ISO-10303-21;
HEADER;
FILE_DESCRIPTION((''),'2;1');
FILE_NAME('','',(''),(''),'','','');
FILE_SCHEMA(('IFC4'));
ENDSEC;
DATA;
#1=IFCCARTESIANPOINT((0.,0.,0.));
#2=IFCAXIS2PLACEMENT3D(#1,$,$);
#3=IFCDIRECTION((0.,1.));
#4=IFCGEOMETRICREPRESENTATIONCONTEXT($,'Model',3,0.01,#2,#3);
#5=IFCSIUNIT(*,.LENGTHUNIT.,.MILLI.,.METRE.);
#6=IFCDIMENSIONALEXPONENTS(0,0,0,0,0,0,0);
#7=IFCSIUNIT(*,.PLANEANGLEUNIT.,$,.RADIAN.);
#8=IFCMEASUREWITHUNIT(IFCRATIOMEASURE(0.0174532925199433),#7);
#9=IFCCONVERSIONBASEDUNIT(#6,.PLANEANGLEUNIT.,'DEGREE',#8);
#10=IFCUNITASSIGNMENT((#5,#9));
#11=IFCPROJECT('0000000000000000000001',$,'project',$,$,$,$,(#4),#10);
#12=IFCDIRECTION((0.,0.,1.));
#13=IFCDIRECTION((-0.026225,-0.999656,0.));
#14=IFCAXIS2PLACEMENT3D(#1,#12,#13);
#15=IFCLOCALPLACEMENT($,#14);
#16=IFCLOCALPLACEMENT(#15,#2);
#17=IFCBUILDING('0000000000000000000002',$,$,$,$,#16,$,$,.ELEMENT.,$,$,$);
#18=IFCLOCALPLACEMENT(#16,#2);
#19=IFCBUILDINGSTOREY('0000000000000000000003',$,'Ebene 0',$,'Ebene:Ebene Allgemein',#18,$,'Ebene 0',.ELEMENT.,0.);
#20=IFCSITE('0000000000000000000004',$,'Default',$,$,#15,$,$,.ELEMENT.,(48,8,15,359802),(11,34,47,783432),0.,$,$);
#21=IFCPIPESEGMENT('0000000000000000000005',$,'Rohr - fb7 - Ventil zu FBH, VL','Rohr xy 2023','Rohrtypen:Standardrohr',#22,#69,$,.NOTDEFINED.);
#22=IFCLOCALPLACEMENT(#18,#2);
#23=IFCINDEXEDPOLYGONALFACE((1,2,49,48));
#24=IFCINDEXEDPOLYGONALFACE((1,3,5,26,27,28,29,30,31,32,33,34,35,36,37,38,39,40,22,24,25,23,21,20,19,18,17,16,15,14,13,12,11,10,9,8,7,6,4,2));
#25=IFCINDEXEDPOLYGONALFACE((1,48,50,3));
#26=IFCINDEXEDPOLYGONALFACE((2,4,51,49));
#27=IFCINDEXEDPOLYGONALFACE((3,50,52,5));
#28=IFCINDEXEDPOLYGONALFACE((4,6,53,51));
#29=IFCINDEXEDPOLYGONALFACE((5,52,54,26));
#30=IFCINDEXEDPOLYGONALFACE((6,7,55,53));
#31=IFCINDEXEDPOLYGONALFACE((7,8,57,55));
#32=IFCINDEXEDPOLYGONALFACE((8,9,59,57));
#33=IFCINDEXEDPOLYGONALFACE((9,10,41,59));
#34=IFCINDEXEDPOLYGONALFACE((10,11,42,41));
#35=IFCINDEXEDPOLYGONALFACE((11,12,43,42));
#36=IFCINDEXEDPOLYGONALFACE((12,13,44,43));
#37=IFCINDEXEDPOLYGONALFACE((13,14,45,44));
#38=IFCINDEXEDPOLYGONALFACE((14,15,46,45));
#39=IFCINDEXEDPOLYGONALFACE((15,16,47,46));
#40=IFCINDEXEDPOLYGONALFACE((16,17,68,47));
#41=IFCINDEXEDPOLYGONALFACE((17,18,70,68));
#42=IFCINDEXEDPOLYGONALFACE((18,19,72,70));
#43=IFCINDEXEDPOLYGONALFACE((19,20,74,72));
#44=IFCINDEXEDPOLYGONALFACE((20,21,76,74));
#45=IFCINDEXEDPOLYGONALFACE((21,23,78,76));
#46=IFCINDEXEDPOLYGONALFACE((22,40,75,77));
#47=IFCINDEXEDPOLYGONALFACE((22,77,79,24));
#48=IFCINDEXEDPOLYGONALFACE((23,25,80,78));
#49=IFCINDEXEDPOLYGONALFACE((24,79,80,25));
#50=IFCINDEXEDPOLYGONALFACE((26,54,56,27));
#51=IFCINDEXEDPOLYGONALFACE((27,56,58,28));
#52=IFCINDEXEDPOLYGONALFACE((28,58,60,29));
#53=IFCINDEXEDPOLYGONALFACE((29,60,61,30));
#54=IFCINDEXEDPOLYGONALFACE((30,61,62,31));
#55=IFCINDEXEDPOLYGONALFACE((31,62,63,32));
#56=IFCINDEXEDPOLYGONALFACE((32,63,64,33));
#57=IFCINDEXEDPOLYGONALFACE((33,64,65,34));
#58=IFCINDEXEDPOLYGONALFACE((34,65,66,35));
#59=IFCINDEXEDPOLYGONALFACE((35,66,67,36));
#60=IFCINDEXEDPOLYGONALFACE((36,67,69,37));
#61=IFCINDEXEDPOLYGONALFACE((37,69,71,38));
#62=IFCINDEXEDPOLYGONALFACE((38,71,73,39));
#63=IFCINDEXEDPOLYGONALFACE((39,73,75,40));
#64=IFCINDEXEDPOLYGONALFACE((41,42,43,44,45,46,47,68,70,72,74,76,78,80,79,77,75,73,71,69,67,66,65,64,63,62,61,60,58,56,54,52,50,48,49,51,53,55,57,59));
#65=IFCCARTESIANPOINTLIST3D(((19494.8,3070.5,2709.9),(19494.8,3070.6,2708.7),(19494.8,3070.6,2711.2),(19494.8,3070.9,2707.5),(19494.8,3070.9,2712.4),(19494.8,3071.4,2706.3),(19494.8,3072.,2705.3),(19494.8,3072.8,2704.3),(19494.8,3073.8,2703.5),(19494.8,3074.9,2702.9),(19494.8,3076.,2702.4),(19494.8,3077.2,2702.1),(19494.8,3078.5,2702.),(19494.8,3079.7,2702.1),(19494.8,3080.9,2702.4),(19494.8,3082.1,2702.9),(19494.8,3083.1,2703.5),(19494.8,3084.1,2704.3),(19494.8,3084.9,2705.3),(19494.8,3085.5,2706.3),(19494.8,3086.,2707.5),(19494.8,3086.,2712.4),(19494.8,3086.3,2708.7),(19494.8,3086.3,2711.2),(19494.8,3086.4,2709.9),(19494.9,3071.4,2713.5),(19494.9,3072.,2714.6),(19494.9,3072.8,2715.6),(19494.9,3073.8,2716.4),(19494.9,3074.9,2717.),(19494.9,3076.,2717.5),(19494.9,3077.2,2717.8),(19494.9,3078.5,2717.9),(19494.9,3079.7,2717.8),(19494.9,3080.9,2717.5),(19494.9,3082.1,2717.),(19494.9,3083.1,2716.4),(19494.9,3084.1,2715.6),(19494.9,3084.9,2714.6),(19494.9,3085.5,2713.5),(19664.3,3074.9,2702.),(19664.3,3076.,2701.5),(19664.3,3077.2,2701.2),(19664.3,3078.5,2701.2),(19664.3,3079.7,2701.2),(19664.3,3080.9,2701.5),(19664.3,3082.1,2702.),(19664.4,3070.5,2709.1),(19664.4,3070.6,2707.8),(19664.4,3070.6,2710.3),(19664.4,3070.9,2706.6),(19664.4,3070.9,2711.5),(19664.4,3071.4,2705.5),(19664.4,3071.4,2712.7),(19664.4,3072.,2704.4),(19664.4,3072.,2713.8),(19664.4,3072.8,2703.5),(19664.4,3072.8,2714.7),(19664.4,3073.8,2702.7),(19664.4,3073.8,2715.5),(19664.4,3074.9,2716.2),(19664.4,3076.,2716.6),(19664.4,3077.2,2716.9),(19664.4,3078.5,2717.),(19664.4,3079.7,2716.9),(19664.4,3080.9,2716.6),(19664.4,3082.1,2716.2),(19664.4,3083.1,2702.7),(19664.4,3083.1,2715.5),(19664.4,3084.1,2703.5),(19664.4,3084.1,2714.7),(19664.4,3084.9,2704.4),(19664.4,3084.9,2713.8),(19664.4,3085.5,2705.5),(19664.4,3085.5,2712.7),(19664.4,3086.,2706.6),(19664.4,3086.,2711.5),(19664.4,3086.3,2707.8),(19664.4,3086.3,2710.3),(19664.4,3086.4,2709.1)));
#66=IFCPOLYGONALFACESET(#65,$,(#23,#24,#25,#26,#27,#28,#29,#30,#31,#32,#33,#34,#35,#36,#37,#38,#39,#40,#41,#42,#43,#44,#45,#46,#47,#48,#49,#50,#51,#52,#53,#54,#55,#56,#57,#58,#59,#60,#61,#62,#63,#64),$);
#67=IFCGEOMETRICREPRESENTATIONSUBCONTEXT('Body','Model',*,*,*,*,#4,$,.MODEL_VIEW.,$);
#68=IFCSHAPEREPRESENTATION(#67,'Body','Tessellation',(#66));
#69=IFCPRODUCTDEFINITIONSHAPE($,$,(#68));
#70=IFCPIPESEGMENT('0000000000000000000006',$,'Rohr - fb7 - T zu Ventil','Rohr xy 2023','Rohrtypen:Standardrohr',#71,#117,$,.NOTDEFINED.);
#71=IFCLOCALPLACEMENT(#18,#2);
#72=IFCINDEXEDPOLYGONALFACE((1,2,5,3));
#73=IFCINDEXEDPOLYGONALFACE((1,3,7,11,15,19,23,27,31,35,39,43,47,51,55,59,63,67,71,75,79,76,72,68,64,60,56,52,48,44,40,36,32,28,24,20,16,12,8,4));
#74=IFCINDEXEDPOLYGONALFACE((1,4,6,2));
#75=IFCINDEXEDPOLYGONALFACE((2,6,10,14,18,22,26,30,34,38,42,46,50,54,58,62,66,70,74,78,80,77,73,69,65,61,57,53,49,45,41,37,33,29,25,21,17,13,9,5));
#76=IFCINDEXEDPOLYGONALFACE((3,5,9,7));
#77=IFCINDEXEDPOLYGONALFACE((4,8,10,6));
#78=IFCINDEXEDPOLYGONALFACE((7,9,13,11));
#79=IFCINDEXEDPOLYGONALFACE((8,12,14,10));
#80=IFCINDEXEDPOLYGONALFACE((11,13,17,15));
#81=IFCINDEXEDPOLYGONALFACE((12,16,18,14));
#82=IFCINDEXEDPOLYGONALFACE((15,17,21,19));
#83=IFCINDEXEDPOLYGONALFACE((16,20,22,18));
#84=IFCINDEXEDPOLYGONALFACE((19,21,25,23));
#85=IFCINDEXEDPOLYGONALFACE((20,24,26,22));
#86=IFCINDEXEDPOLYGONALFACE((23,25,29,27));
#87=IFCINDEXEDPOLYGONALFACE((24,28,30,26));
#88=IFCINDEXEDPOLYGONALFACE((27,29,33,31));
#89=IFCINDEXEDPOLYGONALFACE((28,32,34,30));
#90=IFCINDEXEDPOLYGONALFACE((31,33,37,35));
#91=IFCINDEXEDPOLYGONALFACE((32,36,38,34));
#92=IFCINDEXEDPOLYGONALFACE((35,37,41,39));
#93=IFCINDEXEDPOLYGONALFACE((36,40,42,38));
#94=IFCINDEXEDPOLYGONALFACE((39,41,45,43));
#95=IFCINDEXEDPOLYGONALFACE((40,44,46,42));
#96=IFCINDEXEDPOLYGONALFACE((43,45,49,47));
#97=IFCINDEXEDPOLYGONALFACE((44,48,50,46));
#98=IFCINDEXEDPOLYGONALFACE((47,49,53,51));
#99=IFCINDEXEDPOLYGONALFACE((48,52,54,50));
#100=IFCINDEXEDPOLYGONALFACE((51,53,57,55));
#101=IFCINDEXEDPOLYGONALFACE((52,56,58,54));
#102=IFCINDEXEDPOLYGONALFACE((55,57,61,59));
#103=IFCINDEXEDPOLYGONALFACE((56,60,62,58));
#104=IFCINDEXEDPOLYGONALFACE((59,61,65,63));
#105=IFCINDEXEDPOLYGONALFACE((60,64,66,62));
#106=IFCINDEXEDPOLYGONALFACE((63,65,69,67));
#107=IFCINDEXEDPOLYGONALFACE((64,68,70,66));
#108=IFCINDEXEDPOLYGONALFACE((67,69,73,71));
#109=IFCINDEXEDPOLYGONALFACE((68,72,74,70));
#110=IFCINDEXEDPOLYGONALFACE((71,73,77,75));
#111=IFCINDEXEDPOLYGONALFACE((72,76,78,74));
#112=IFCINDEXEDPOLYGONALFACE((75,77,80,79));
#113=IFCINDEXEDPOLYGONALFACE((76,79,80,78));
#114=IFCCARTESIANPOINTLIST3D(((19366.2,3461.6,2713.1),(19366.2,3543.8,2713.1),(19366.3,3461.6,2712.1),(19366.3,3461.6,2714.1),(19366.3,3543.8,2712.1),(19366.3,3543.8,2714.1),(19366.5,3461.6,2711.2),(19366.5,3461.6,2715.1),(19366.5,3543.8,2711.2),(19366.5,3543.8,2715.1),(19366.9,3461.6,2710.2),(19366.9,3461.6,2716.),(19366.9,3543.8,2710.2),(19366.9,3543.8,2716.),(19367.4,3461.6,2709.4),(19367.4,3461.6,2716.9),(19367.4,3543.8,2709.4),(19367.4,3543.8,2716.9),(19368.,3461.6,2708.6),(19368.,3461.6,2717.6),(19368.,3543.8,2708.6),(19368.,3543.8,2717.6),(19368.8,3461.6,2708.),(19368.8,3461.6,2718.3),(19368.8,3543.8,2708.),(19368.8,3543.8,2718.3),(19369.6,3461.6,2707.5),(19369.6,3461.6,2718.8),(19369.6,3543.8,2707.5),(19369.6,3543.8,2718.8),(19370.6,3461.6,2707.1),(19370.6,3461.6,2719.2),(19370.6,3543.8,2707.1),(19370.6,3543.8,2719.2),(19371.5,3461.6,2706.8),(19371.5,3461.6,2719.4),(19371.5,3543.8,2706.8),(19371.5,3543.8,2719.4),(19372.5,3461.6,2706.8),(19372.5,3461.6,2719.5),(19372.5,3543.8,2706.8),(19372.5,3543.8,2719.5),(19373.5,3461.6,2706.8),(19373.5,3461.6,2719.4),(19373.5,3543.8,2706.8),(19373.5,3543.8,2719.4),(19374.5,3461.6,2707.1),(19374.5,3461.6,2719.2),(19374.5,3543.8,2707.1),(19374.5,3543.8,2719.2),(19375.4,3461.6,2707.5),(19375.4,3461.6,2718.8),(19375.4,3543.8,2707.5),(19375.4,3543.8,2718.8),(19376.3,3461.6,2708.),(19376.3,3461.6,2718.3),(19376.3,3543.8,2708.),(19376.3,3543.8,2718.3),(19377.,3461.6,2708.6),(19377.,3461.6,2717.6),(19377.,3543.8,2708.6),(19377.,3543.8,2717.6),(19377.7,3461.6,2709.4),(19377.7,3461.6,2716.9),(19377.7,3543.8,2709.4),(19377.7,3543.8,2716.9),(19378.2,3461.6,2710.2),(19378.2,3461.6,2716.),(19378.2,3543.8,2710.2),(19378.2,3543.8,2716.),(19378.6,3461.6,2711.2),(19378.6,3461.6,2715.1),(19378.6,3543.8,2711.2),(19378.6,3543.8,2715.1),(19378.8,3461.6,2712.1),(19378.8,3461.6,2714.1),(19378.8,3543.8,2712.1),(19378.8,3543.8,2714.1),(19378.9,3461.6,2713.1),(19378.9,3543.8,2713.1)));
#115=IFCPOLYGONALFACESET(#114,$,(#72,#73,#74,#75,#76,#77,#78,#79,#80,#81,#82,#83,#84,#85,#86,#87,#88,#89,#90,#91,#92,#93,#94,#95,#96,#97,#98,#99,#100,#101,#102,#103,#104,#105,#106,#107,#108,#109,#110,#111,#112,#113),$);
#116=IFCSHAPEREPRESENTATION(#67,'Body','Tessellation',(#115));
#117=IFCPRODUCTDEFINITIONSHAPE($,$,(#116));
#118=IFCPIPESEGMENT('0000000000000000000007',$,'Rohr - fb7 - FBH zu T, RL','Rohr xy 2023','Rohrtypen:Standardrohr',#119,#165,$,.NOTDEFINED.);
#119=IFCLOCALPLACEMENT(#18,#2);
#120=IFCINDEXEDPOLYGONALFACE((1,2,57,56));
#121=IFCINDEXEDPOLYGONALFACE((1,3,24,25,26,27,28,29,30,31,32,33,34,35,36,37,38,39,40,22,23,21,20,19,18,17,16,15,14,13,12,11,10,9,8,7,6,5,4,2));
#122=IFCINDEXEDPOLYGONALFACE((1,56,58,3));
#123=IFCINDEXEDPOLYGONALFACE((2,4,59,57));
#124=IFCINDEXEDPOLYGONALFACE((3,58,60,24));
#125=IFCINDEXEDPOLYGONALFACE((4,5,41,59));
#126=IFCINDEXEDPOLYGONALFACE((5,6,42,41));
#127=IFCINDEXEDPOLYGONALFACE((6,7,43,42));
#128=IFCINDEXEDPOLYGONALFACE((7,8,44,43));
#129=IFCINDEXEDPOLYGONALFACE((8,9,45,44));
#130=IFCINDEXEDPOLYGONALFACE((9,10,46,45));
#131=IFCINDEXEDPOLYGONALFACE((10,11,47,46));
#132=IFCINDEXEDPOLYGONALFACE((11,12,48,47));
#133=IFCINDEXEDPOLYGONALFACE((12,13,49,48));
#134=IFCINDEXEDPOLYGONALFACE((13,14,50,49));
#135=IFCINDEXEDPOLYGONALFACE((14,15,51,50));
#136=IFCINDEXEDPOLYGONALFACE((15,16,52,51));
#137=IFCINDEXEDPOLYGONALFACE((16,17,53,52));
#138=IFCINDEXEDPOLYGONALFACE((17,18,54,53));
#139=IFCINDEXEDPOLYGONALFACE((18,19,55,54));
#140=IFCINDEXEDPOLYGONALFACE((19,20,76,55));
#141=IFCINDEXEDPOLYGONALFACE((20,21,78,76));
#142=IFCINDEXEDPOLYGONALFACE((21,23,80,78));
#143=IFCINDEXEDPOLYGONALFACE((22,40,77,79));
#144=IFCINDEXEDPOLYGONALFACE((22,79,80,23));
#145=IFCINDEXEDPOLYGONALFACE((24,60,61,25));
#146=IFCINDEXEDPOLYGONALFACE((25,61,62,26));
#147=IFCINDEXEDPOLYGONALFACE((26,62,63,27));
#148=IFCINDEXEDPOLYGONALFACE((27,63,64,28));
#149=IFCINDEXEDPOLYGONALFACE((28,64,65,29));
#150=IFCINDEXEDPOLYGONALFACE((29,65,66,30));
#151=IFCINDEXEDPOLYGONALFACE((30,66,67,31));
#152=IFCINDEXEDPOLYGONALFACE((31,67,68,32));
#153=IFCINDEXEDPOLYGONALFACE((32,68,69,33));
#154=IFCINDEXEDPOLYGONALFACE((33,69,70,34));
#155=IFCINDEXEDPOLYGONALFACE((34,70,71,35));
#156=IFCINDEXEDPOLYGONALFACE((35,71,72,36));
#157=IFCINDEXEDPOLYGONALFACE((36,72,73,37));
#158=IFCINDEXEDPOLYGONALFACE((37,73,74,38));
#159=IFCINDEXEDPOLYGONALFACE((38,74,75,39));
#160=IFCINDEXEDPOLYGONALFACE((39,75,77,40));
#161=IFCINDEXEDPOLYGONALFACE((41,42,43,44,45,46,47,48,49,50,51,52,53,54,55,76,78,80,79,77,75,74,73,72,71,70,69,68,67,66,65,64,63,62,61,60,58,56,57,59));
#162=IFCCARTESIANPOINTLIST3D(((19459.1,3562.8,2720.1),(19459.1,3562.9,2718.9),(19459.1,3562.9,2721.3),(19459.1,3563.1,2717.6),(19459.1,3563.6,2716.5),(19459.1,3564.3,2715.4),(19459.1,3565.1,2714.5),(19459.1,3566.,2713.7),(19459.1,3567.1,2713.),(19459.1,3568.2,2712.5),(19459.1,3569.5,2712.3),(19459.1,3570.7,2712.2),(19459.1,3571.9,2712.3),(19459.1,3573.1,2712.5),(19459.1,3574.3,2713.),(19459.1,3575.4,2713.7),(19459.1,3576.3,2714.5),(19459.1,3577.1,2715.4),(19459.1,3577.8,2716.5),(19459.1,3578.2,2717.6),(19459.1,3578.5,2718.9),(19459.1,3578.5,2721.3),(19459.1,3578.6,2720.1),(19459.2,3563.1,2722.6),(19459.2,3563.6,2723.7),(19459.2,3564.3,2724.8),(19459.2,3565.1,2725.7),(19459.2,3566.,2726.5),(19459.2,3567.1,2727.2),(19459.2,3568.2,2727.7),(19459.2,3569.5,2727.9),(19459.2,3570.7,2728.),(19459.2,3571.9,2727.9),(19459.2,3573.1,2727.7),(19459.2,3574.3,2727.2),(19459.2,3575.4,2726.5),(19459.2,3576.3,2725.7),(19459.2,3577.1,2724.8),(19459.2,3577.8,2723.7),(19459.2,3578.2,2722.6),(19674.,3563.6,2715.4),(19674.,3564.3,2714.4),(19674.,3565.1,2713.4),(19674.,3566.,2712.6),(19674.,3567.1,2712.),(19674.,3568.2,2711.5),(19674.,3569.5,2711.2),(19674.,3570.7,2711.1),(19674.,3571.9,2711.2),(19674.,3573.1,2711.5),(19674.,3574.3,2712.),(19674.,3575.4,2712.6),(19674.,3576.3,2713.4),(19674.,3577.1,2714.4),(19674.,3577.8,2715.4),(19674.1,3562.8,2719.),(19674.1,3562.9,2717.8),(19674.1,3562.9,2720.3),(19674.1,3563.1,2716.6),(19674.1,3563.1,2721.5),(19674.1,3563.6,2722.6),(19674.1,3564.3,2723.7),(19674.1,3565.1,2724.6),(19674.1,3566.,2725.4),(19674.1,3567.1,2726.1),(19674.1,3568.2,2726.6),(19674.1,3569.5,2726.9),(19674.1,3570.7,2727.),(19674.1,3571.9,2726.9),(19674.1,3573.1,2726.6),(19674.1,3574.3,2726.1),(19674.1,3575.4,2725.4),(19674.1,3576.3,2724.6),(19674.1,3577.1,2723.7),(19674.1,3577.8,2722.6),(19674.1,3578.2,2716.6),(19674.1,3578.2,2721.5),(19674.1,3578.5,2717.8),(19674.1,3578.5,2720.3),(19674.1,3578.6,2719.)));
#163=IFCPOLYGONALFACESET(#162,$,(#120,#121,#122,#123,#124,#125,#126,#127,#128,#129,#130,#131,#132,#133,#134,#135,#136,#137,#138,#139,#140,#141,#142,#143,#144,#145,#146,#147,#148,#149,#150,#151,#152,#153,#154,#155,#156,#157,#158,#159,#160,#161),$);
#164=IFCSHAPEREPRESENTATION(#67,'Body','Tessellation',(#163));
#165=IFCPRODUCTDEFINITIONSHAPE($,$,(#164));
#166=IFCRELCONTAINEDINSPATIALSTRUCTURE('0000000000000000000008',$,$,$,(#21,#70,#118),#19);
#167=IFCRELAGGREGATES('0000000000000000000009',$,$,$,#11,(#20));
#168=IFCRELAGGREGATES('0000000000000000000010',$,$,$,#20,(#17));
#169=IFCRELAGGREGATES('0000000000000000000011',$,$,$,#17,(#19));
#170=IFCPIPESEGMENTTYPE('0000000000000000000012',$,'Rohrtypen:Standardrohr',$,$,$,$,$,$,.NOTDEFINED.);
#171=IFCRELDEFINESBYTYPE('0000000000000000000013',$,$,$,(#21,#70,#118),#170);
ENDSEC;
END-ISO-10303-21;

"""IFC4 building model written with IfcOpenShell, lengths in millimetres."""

from ifc_helpers import new_model, entity, si_unit, converted_unit, direction, frame, origin, place, context, subcontext, project, spatial, indexed_curve, outline, extrude, type_object, element, save


model = new_model("IFC4")

# Units and contexts
model_context = context("Model", 3, precision=0.01, world=origin(), true_north=direction((0.0, 1.0)))
body_context = subcontext(model_context, "Body", "Model", "MODEL_VIEW")
ifc_project = project(units=[si_unit("LENGTHUNIT", "METRE", prefix="MILLI"), converted_unit("PLANEANGLEUNIT", "DEGREE", entity("IfcRatioMeasure", 0.0174532925199433), si_unit("PLANEANGLEUNIT", "RADIAN"), dimensions=[0, 0, 0, 0, 0, 0, 0])], contexts=[model_context])

# Site, building, storey
site_placement = place(None, frame((0.0, 0.0, 0.0), z_axis=(0.0, 0.0, 1.0), x_axis=(-0.026225, -0.999656, 0.0)))
site = spatial("IfcSite", under=ifc_project, at=site_placement, Name="Default", CompositionType="ELEMENT", RefLatitude=(48, 8, 15, 359802), RefLongitude=(11, 34, 47, 783432), RefElevation=0.0)
building_placement = place(site_placement, origin())
building = spatial("IfcBuilding", under=site, at=building_placement, CompositionType="ELEMENT")
storey_placement = place(building_placement, origin())
storey = spatial("IfcBuildingStorey", under=building, at=storey_placement, Name="Ebene 0", ObjectType="Ebene:Ebene Allgemein", LongName="Ebene 0", CompositionType="ELEMENT", Elevation=0.0)

# Pipe segments
pipe_segment_type = type_object("IfcPipeSegmentType", Name="Rohrtypen:Standardrohr", PredefinedType="NOTDEFINED")
pipe_segment_1_placement = place(storey_placement, origin())
element("IfcPipeSegment", 1, at=pipe_segment_1_placement, inside=storey, type_object=pipe_segment_type, Name="Rohr - fb7 - Ventil zu FBH, VL", Description="Rohr xy 2023", ObjectType="Rohrtypen:Standardrohr", PredefinedType="NOTDEFINED", context=body_context, shape_type="SweptSolid", body=[
    extrude(outline(indexed_curve([(7.9, 0.0), (7.8, 1.2), (7.6, 2.5), (7.1, 3.6), (6.4, 4.7), (5.6, 5.6), (4.7, 6.4), (3.6, 7.1), (2.5, 7.6), (1.2, 7.8), (0.0, 7.9), (-1.2, 7.8), (-2.5, 7.6), (-3.6, 7.1), (-4.7, 6.4), (-5.6, 5.6), (-6.4, 4.7), (-7.1, 3.6), (-7.6, 2.5), (-7.8, 1.2), (-7.9, 0.0), (-7.8, -1.2), (-7.6, -2.5), (-7.1, -3.6), (-6.4, -4.7), (-5.6, -5.6), (-4.7, -6.4), (-3.6, -7.1), (-2.5, -7.6), (-1.2, -7.8), (0.0, -7.9), (1.2, -7.8), (2.5, -7.6), (3.6, -7.1), (4.7, -6.4), (5.6, -5.6), (6.4, -4.7), (7.1, -3.6), (7.6, -2.5), (7.8, -1.2), (7.9, 0.0)], self_intersect=False)), frame((19494.8, 3078.5, 2709.9), z_axis=(0.999988, 0.0, -0.005), x_axis=(0.0, 1.0, 0.0)), (0.0, 0.0, 1.0), 169.5),
])
pipe_segment_2_placement = place(storey_placement, origin())
element("IfcPipeSegment", 2, at=pipe_segment_2_placement, inside=storey, type_object=pipe_segment_type, Name="Rohr - fb7 - T zu Ventil", Description="Rohr xy 2023", ObjectType="Rohrtypen:Standardrohr", PredefinedType="NOTDEFINED", context=body_context, shape_type="SweptSolid", body=[
    extrude(outline(indexed_curve([(6.4, 0.0), (6.3, 1.0), (6.0, 2.0), (5.7, 2.9), (5.1, 3.7), (4.5, 4.5), (3.7, 5.1), (2.9, 5.7), (2.0, 6.0), (1.0, 6.3), (0.0, 6.4), (-1.0, 6.3), (-2.0, 6.0), (-2.9, 5.7), (-3.7, 5.1), (-4.5, 4.5), (-5.1, 3.7), (-5.7, 2.9), (-6.0, 2.0), (-6.3, 1.0), (-6.3, 0.0), (-6.3, -1.0), (-6.0, -2.0), (-5.7, -2.9), (-5.1, -3.7), (-4.5, -4.5), (-3.7, -5.1), (-2.9, -5.7), (-2.0, -6.0), (-1.0, -6.3), (0.0, -6.4), (1.0, -6.3), (2.0, -6.0), (2.9, -5.7), (3.7, -5.1), (4.5, -4.5), (5.1, -3.7), (5.7, -2.9), (6.0, -2.0), (6.3, -1.0), (6.4, 0.0)], self_intersect=False)), frame((19372.5, 3461.6, 2713.1), z_axis=(0.0, 1.0, 0.0), x_axis=(-1.0, 0.0, 0.0)), (0.0, 0.0, 1.0), 82.2),
])
pipe_segment_3_placement = place(storey_placement, origin())
element("IfcPipeSegment", 3, at=pipe_segment_3_placement, inside=storey, type_object=pipe_segment_type, Name="Rohr - fb7 - FBH zu T, RL", Description="Rohr xy 2023", ObjectType="Rohrtypen:Standardrohr", PredefinedType="NOTDEFINED", context=body_context, shape_type="SweptSolid", body=[
    extrude(outline(indexed_curve([(7.9, 0.0), (7.8, 1.2), (7.6, 2.5), (7.1, 3.6), (6.4, 4.7), (5.6, 5.6), (4.7, 6.4), (3.6, 7.1), (2.5, 7.6), (1.2, 7.8), (0.0, 7.9), (-1.2, 7.8), (-2.5, 7.6), (-3.6, 7.1), (-4.7, 6.4), (-5.6, 5.6), (-6.4, 4.7), (-7.1, 3.6), (-7.6, 2.5), (-7.8, 1.2), (-7.9, 0.0), (-7.8, -1.2), (-7.6, -2.5), (-7.1, -3.6), (-6.4, -4.7), (-5.6, -5.6), (-4.7, -6.4), (-3.6, -7.1), (-2.5, -7.6), (-1.2, -7.8), (0.0, -7.9), (1.2, -7.8), (2.5, -7.6), (3.6, -7.1), (4.7, -6.4), (5.6, -5.6), (6.4, -4.7), (7.1, -3.6), (7.6, -2.5), (7.8, -1.2), (7.9, 0.0)], self_intersect=False)), frame((19674.1, 3570.7, 2719.0), z_axis=(-0.999988, 0.0, 0.005), x_axis=(0.0, 1.0, 0.0)), (0.0, 0.0, 1.0), 214.9),
])

save(model, "model.ifc")
